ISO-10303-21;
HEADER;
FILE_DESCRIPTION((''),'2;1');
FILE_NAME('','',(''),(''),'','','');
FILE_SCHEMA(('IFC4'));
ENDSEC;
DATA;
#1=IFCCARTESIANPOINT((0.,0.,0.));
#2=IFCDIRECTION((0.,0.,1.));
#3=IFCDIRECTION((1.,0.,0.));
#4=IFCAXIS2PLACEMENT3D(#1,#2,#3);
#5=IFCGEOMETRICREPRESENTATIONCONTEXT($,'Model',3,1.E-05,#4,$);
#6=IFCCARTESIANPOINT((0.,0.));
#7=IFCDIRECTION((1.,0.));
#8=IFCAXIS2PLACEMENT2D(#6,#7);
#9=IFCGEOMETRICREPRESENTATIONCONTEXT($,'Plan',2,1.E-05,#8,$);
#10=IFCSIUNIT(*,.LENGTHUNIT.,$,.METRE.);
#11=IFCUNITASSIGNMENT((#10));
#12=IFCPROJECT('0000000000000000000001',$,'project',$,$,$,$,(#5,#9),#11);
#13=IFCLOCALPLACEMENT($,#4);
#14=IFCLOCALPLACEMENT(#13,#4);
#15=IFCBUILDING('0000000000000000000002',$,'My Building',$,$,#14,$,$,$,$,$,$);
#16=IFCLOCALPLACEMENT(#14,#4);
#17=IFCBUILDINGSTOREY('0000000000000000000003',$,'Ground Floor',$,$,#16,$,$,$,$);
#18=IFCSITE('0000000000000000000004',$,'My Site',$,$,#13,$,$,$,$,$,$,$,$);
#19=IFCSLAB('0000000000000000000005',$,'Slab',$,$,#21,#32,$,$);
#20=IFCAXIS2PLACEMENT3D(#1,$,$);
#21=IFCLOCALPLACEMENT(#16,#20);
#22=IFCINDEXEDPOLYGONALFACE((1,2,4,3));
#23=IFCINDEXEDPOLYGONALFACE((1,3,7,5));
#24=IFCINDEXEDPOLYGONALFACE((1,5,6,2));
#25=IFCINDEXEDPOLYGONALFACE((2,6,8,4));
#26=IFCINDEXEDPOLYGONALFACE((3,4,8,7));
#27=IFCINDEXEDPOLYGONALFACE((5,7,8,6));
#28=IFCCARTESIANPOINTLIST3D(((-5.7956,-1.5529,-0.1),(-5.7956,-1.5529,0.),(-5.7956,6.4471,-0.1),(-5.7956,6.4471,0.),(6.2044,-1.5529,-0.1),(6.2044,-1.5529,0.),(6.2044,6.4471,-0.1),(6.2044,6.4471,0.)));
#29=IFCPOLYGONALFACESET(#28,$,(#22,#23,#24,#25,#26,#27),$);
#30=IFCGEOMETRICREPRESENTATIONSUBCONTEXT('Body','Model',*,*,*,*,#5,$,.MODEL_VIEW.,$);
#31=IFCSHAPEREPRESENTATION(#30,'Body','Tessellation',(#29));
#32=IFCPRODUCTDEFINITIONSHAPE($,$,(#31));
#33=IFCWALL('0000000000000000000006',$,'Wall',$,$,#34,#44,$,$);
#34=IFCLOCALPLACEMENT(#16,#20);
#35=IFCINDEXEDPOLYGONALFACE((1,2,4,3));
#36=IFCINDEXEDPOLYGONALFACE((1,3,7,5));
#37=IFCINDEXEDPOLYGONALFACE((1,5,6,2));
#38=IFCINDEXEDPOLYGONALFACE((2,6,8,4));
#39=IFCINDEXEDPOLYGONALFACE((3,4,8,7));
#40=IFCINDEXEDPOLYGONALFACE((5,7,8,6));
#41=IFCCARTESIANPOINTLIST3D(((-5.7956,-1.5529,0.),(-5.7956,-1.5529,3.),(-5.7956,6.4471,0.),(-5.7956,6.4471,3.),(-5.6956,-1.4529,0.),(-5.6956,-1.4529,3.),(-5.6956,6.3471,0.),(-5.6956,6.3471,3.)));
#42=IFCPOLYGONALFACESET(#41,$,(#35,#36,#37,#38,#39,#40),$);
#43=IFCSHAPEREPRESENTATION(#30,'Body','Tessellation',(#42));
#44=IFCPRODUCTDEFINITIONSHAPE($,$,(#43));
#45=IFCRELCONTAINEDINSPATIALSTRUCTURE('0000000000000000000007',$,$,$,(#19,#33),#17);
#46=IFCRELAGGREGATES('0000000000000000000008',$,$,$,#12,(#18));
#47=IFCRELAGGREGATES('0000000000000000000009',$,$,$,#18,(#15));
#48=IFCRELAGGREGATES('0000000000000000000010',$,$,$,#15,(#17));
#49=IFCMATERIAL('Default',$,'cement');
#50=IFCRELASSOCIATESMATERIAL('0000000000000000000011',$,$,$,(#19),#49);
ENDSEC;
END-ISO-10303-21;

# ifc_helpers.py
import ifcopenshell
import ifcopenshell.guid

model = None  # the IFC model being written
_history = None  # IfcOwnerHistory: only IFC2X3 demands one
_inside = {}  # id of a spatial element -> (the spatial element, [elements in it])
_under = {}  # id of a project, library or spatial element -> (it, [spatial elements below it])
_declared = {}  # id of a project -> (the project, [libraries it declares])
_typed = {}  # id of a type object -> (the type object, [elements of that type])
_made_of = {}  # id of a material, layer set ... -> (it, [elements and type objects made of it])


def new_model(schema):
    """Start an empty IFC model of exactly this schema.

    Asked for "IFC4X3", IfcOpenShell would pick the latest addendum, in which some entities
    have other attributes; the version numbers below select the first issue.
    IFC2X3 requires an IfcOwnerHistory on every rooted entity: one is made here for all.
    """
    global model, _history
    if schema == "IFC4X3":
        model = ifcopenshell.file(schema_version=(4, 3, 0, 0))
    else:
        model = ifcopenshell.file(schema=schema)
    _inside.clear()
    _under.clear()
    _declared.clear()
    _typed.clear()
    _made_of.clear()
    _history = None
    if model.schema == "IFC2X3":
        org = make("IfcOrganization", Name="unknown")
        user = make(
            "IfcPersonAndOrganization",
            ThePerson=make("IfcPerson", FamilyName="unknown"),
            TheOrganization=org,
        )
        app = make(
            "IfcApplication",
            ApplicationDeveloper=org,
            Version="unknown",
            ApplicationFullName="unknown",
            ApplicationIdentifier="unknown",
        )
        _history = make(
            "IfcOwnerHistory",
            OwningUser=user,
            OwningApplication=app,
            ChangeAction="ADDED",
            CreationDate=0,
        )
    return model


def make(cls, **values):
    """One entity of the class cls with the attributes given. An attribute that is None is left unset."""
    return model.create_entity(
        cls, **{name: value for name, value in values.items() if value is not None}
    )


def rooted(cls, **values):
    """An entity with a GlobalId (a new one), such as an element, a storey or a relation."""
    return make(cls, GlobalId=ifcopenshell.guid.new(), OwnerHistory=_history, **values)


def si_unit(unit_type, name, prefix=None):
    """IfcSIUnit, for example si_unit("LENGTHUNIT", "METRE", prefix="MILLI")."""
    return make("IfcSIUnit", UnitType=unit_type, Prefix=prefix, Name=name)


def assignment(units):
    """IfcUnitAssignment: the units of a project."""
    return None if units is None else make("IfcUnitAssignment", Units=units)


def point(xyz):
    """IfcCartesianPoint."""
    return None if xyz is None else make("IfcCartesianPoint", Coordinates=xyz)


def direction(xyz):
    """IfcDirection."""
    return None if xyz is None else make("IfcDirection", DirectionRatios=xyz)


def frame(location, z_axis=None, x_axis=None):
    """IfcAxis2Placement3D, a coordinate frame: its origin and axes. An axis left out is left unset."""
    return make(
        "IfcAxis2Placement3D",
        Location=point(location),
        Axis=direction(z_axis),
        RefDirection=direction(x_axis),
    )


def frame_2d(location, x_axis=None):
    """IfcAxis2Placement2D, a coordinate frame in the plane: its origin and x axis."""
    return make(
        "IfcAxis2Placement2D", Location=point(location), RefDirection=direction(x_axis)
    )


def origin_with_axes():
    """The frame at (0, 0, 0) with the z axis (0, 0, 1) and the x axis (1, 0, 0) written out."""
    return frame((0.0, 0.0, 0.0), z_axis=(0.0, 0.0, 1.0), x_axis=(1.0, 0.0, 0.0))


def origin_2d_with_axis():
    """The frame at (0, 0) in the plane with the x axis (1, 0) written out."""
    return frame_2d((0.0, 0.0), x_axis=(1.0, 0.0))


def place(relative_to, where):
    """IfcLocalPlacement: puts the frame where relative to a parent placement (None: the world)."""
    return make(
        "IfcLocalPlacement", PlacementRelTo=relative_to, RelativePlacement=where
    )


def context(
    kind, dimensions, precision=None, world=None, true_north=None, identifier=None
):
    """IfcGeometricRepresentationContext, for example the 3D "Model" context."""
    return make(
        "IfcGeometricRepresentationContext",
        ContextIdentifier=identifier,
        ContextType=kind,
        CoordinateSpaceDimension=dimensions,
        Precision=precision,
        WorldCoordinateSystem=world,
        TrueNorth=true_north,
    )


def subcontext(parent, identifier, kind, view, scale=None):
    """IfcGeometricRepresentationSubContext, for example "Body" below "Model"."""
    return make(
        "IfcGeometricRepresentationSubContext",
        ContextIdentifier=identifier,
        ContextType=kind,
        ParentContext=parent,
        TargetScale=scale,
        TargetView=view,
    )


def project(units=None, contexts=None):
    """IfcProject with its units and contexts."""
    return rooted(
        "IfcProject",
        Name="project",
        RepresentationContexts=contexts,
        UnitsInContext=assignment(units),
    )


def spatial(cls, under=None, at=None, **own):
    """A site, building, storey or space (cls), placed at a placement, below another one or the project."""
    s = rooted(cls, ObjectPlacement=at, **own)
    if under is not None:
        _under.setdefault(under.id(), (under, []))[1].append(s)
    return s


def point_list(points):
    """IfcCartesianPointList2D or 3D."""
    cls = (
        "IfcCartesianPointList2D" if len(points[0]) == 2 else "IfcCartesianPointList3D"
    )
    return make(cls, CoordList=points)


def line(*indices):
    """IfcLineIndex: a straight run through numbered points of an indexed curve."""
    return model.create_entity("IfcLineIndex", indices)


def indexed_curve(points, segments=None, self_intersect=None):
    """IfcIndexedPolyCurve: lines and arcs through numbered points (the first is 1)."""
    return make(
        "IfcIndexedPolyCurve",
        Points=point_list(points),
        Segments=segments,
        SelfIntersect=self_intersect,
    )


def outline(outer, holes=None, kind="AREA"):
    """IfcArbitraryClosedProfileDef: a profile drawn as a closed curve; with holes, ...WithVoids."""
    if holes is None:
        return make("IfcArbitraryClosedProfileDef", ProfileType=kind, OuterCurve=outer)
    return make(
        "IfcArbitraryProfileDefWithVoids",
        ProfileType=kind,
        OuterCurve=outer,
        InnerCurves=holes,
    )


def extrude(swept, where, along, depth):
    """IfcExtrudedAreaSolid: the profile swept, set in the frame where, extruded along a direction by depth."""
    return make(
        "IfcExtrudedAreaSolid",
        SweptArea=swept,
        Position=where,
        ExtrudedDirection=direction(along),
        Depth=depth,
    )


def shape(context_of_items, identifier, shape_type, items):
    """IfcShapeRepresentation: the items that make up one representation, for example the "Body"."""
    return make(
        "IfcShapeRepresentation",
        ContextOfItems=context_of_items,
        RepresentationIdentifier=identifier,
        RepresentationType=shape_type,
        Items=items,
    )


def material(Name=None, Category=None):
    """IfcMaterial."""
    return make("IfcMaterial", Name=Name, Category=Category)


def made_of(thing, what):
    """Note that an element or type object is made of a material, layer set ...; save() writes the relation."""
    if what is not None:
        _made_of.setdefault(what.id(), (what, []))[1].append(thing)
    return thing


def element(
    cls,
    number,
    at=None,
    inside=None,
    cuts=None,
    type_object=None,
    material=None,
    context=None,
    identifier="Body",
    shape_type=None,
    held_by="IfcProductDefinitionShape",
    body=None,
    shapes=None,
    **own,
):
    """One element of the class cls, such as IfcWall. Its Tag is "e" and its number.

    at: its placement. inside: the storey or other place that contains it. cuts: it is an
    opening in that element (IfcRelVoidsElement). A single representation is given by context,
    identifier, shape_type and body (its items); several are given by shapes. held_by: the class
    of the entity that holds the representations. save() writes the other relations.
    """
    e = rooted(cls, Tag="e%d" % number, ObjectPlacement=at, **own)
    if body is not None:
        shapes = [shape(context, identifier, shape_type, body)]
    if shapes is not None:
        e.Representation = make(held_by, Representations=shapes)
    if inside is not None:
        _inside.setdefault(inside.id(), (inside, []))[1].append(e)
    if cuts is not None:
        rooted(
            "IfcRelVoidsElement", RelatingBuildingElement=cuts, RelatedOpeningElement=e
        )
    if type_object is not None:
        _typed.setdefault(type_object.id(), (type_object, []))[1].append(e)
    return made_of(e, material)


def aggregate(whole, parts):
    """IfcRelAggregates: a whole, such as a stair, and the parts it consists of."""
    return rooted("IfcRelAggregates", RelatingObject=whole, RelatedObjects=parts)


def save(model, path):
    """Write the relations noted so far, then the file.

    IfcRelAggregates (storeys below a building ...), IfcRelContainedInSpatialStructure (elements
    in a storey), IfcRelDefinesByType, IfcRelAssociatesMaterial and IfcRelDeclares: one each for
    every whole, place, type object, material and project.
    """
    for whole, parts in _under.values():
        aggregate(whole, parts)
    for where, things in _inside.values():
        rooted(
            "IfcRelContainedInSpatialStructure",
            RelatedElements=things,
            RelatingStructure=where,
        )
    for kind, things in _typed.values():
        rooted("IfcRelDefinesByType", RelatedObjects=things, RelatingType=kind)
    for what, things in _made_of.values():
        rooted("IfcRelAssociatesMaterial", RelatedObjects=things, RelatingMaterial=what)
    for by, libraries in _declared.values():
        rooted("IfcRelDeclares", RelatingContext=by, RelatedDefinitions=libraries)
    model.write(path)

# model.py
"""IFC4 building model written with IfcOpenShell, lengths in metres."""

from ifc_helpers import new_model, si_unit, frame, origin_with_axes, origin_2d_with_axis, place, context, subcontext, project, spatial, line, indexed_curve, outline, extrude, material, element, save


model = new_model("IFC4")

# Units and contexts
model_context = context("Model", 3, precision=1e-05, world=origin_with_axes())
plan_context = context("Plan", 2, precision=1e-05, world=origin_2d_with_axis())
body_context_1 = subcontext(model_context, "Body", "Model", "MODEL_VIEW")
ifc_project = project(units=[si_unit("LENGTHUNIT", "METRE")], contexts=[model_context, plan_context])

# Site, building, storey
site_placement = place(None, origin_with_axes())
site = spatial("IfcSite", under=ifc_project, at=site_placement, Name="My Site")
building_placement = place(site_placement, origin_with_axes())
building = spatial("IfcBuilding", under=site, at=building_placement, Name="My Building")
storey_placement = place(building_placement, origin_with_axes())
storey = spatial("IfcBuildingStorey", under=building, at=storey_placement, Name="Ground Floor")

# Slab
ifc_material = material(Name="Default", Category="cement")
slab_placement = place(storey_placement, frame((-5.7956, -1.5529, 0.0), z_axis=(0.0, 0.0, 1.0), x_axis=(1.0, 0.0, 0.0)))
element("IfcSlab", 1, at=slab_placement, inside=storey, material=ifc_material, Name="Slab", context=body_context_1, shape_type="SweptSolid", body=[
    extrude(outline(indexed_curve([(0.0, 0.0), (12.0, 0.0), (12.0, 8.0), (0.0, 8.0), (0.0, 0.0)])), frame((0.0, 0.0, -0.1), z_axis=(0.0, 0.0, 1.0), x_axis=(1.0, 0.0, 0.0)), (0.0, 0.0, 1.0), 0.1),
])

# Wall
wall_1_placement = place(storey_placement, frame((-5.7956, 6.4471, 0.0), z_axis=(0.0, 0.0, 1.0), x_axis=(0.0, -1.0, 0.0)))
element("IfcWall", 2, at=wall_1_placement, inside=storey, Name="Wall", context=body_context_1, shape_type="SweptSolid", body=[
    extrude(outline(indexed_curve([(0.0, 0.0), (0.1, 0.1), (7.9, 0.1), (8.0, 0.0)], segments=[line(1, 2, 3, 4, 1)])), origin_with_axes(), (0.0, 0.0, 1.0), 3.0),
])

save(model, "model.ifc")
